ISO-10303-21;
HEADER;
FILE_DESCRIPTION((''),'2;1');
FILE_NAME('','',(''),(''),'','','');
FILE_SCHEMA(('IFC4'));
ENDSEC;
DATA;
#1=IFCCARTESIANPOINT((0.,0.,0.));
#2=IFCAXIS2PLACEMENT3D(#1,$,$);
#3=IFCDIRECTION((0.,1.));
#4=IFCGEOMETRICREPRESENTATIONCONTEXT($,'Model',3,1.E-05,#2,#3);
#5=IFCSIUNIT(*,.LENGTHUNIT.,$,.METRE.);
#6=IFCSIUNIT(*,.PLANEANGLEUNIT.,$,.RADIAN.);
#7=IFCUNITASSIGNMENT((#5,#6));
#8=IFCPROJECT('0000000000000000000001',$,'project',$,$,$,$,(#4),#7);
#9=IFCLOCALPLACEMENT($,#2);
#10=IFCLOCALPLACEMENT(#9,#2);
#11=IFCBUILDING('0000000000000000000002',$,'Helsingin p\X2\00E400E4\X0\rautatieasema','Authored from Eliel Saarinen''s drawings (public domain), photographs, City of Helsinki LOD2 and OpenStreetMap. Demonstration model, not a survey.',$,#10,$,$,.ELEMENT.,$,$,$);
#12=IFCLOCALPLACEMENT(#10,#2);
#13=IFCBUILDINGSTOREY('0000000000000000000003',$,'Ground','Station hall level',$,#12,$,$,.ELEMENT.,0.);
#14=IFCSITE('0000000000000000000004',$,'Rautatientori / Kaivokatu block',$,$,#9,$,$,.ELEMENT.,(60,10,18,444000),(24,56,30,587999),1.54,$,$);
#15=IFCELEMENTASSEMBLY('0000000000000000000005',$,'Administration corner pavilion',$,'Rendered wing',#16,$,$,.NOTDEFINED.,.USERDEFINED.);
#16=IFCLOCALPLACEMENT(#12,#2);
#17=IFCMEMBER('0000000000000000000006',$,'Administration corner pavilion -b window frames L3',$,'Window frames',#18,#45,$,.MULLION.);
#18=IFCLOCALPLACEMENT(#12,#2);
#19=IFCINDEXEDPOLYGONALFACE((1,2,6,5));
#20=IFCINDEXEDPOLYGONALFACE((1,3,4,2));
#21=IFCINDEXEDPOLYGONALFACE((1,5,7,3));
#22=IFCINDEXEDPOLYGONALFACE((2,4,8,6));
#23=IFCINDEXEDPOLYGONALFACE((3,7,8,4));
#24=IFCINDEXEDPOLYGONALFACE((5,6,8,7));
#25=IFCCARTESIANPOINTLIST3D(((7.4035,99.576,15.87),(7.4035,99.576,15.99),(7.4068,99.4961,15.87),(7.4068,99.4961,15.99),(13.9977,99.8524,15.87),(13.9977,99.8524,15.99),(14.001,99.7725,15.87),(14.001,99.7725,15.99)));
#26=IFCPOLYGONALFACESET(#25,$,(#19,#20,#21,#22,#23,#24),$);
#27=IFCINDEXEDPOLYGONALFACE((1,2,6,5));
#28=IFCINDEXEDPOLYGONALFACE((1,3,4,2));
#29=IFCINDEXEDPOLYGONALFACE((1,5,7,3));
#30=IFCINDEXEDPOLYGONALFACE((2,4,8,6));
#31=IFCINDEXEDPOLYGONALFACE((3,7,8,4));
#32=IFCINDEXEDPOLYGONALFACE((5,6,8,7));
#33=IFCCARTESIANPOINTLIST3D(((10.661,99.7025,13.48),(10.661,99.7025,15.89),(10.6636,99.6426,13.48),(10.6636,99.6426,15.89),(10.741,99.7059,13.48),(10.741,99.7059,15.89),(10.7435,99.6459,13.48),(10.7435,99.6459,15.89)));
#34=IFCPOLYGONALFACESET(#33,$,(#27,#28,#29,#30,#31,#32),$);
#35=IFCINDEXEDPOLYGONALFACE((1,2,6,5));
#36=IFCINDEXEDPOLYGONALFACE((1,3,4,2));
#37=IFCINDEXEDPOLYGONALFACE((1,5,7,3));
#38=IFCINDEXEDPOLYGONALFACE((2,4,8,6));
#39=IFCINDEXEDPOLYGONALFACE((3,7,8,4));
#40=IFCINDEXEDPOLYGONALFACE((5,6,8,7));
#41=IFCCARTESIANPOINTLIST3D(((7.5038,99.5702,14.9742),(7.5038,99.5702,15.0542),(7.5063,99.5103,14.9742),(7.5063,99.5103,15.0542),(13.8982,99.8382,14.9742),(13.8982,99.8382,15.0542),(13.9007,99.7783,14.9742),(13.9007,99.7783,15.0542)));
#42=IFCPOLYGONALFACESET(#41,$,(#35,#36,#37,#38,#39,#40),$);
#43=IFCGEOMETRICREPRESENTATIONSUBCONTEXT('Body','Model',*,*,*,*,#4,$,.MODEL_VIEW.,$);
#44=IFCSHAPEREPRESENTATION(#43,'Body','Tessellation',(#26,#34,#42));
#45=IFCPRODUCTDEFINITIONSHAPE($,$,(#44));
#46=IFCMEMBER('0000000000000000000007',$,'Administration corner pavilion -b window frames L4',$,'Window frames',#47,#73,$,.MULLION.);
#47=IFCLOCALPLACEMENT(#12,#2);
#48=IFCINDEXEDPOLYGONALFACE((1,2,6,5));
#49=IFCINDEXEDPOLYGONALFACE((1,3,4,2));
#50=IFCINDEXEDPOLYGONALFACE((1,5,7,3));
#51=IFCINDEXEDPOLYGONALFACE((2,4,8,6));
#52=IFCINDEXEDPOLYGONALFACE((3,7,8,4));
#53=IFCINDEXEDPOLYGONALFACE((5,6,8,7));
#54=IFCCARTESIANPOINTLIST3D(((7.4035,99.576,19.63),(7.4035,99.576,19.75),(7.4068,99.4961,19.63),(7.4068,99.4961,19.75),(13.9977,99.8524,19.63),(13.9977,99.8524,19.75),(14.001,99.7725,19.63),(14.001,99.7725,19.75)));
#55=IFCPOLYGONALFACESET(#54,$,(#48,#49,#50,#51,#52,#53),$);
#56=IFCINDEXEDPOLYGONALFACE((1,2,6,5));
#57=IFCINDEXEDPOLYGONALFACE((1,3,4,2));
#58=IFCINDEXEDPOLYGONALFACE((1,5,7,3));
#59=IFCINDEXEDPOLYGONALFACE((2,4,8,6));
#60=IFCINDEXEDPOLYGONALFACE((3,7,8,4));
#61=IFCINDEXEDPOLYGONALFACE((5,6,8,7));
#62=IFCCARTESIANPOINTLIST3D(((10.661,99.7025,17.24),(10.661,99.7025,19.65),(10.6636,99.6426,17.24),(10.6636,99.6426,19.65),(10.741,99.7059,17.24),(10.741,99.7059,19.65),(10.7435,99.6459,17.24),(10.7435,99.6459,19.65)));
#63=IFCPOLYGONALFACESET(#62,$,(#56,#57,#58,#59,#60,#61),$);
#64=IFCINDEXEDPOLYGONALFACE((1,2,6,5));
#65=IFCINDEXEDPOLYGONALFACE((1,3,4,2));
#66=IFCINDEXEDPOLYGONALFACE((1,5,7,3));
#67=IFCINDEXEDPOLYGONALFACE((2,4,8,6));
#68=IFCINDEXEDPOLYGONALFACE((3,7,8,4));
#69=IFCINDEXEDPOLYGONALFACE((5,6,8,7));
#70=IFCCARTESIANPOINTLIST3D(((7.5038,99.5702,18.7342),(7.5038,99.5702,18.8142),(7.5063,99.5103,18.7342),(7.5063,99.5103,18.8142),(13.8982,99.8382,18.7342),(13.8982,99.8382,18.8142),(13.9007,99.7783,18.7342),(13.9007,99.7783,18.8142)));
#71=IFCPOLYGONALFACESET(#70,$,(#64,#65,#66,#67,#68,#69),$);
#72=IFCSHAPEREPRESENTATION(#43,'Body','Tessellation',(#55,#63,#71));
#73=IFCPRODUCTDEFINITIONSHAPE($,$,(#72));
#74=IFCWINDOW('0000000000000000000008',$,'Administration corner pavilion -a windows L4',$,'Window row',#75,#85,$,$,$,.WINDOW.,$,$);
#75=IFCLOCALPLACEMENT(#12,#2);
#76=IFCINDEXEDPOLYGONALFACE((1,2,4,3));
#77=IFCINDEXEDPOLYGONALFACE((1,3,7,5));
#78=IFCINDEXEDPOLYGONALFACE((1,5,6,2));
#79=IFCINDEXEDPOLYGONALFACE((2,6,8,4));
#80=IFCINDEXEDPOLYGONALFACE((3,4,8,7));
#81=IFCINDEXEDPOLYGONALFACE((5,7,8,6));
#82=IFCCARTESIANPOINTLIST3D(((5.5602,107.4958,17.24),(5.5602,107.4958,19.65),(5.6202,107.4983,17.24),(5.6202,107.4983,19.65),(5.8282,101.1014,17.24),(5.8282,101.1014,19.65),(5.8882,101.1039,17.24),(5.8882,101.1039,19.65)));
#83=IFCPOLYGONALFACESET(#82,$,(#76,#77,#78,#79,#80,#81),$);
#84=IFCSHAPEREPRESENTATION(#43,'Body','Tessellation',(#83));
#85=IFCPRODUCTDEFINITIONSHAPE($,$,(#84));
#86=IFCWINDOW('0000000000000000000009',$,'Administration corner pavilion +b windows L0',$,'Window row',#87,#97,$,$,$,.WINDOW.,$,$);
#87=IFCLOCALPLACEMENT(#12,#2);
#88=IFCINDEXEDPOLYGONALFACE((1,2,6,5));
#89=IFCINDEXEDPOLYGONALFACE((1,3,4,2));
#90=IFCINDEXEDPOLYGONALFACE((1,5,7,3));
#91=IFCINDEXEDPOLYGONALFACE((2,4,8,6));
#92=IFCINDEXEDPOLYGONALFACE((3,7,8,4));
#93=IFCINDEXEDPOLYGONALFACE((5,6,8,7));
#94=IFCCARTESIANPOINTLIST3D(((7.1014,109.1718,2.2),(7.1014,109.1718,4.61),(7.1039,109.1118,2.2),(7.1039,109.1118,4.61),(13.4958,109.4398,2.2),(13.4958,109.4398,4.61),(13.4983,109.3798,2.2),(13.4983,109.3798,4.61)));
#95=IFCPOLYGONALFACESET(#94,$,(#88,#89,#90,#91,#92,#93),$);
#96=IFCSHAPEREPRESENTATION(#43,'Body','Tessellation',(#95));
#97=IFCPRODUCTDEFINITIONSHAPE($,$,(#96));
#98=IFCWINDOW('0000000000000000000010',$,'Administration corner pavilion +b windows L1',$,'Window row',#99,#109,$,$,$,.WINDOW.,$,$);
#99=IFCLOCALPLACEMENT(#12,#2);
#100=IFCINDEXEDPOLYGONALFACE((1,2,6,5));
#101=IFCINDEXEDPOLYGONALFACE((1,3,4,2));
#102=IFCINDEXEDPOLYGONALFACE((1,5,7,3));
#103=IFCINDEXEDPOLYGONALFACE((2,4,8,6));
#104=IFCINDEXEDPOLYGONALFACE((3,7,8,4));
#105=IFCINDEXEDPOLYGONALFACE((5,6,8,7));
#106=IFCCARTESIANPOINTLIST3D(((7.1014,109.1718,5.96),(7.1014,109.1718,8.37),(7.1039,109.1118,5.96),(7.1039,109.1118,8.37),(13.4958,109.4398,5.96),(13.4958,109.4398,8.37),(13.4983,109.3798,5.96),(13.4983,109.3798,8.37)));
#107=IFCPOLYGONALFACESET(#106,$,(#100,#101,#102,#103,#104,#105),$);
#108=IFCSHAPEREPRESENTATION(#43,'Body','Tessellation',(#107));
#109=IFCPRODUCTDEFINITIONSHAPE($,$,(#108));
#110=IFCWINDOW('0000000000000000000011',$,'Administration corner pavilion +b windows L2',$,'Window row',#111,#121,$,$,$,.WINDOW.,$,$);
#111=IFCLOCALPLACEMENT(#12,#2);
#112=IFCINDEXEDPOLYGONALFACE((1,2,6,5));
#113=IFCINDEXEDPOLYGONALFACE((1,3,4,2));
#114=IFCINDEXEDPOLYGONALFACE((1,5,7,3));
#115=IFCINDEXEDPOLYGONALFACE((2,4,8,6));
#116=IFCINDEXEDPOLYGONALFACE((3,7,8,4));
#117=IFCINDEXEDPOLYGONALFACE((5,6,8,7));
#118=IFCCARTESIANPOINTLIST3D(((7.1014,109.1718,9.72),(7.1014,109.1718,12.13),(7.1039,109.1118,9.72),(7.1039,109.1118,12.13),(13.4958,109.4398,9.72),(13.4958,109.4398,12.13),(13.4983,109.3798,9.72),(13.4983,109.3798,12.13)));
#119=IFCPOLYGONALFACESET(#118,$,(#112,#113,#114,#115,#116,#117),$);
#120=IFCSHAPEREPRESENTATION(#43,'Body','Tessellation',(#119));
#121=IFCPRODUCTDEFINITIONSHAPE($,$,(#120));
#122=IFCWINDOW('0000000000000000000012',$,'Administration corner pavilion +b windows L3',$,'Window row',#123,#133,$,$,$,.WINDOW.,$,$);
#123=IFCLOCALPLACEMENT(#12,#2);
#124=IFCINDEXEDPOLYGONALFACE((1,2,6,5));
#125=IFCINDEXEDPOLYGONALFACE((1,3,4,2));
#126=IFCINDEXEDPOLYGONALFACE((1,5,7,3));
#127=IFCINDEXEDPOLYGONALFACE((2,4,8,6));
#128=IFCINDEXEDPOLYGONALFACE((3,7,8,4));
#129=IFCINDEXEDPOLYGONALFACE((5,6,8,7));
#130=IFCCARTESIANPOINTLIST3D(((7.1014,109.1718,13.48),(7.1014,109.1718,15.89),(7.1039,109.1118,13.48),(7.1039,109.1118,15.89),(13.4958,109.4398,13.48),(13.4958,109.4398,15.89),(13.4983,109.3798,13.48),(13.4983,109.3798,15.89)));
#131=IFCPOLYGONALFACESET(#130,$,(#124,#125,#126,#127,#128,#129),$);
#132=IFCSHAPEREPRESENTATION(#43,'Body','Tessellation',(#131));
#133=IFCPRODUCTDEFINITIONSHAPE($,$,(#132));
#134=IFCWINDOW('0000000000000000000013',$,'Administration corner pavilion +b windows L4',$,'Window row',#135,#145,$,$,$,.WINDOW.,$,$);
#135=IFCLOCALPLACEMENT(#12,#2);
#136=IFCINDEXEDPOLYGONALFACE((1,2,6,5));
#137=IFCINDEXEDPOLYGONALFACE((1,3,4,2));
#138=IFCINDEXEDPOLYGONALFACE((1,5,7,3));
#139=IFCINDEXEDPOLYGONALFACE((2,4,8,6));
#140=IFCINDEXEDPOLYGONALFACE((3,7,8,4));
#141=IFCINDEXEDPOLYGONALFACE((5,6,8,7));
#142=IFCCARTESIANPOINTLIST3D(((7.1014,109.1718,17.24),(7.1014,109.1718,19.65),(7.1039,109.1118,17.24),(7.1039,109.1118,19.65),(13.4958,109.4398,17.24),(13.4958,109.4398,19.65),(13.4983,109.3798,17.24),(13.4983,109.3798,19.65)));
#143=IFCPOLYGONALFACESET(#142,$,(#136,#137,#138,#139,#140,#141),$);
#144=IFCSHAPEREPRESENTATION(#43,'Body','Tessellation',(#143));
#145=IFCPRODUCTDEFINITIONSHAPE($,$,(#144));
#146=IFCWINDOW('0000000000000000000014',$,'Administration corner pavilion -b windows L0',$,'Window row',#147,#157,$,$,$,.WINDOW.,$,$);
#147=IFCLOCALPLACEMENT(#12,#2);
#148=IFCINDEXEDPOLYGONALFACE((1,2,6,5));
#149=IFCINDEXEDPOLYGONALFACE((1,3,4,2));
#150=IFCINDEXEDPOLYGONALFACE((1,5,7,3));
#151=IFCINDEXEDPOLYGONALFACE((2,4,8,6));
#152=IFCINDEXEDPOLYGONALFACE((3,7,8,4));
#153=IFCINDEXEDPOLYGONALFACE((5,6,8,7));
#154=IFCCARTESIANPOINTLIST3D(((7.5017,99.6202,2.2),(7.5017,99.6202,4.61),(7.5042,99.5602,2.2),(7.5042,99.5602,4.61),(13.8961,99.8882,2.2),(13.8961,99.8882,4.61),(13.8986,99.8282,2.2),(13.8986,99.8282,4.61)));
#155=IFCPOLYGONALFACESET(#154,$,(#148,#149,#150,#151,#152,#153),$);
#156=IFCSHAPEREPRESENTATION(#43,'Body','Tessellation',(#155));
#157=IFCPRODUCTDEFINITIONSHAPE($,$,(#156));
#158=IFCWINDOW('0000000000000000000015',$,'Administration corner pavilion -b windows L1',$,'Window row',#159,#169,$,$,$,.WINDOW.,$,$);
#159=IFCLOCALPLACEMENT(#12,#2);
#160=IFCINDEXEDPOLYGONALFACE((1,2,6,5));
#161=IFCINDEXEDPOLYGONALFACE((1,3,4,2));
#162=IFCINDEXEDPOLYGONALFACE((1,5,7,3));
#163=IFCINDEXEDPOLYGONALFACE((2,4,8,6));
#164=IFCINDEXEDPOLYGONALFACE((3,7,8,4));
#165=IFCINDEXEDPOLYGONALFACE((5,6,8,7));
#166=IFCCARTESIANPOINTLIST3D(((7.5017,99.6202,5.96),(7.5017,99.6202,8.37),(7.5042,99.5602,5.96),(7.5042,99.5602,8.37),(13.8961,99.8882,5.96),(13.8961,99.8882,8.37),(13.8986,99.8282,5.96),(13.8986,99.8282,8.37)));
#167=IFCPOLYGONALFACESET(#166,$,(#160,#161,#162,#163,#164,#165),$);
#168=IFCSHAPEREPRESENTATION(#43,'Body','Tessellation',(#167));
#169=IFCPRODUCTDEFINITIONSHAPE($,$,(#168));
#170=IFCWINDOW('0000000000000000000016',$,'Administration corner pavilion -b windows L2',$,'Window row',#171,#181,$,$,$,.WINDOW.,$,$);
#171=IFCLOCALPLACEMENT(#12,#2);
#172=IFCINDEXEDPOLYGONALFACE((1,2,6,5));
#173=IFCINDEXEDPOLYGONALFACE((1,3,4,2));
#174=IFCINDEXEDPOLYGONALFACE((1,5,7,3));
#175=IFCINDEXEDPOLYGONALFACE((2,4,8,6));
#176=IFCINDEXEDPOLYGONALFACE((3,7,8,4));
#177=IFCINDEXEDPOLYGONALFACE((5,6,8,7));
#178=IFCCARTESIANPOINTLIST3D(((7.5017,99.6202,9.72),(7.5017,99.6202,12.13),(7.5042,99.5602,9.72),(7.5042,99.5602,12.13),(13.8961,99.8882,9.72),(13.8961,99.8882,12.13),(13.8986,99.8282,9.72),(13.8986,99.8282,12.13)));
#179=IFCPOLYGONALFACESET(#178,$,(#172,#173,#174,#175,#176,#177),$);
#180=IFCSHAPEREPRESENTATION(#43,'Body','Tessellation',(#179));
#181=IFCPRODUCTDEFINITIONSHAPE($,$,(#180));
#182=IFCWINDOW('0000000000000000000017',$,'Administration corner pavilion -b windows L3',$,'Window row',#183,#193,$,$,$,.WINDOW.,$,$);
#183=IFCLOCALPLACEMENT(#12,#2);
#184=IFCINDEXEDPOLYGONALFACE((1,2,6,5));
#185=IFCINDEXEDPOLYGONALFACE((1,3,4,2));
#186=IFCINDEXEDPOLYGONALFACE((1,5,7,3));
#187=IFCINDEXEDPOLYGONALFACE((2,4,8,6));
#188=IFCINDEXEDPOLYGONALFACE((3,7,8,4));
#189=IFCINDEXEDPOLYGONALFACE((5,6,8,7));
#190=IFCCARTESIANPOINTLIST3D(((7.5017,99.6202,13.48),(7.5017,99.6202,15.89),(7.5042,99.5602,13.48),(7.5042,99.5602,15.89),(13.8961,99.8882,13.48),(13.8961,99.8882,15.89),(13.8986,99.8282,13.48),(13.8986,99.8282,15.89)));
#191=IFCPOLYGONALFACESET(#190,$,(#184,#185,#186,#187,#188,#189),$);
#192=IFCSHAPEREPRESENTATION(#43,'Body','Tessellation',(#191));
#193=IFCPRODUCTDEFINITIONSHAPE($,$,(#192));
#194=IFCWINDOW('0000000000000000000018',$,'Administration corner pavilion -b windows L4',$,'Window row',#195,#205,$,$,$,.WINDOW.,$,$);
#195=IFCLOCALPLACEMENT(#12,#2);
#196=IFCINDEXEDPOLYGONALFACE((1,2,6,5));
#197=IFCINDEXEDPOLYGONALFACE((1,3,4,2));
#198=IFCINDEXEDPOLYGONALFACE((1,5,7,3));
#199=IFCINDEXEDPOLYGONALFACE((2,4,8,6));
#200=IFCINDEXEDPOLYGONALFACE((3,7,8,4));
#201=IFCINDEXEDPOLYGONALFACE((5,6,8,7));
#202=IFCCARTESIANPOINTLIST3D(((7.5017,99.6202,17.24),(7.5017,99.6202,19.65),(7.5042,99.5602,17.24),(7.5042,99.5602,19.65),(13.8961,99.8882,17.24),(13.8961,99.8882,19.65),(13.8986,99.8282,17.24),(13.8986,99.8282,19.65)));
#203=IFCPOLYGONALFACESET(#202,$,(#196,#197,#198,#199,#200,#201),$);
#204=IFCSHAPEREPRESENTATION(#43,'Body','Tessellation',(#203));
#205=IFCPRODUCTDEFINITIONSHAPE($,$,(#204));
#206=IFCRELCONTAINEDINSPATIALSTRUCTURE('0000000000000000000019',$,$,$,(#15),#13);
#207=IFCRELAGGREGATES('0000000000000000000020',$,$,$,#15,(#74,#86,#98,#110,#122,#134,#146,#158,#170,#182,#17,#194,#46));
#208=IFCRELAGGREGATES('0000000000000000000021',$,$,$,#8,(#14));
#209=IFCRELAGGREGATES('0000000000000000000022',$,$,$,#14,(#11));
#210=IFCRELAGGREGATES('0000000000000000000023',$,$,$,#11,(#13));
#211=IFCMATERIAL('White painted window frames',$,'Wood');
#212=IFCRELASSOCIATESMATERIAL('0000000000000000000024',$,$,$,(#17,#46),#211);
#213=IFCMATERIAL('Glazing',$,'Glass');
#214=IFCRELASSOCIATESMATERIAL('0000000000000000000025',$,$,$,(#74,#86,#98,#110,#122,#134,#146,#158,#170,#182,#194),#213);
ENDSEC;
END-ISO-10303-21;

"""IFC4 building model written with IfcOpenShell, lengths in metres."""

from ifc_helpers import new_model, si_unit, direction, frame, frame_2d, origin, place, context, subcontext, project, spatial, rectangle, extrude, material, element, aggregate, save


model = new_model("IFC4")

# Units and contexts
model_context = context("Model", 3, precision=1e-05, world=origin(), true_north=direction((0.0, 1.0)))
body_context = subcontext(model_context, "Body", "Model", "MODEL_VIEW")
ifc_project = project(units=[si_unit("LENGTHUNIT", "METRE"), si_unit("PLANEANGLEUNIT", "RADIAN")], contexts=[model_context])

# Site, building, storey
site_placement = place(None, origin())
site = spatial("IfcSite", under=ifc_project, at=site_placement, Name="Rautatientori / Kaivokatu block", CompositionType="ELEMENT", RefLatitude=(60, 10, 18, 444000), RefLongitude=(24, 56, 30, 587999), RefElevation=1.54)
building_placement = place(site_placement, origin())
building = spatial("IfcBuilding", under=site, at=building_placement, Name="Helsingin päärautatieasema", Description="Authored from Eliel Saarinen's drawings (public domain), photographs, City of Helsinki LOD2 and OpenStreetMap. Demonstration model, not a survey.", CompositionType="ELEMENT")
storey_placement = place(building_placement, origin())
storey = spatial("IfcBuildingStorey", under=building, at=storey_placement, Name="Ground", Description="Station hall level", CompositionType="ELEMENT", Elevation=0.0)

# Element assembly, members, windows
assembly_placement = place(building_placement, origin())
assembly = element("IfcElementAssembly", 1, at=assembly_placement, inside=storey, Name="Administration corner pavilion", ObjectType="Rendered wing", AssemblyPlace="NOTDEFINED", PredefinedType="USERDEFINED")
ifc_material_1 = material(Name="White painted window frames", Category="Wood")
member_1_placement = place(building_placement, origin())
member_1 = element("IfcMember", 2, at=member_1_placement, material=ifc_material_1, Name="Administration corner pavilion -b window frames L3", ObjectType="Window frames", PredefinedType="MULLION", context=body_context, shape_type="SweptSolid", body=[
    extrude(rectangle(XDim=6.6, YDim=0.08, at=frame_2d((0.0, 0.0), x_axis=(0.999123, 0.041876))), frame((10.7023, 99.6742, 15.87)), (0.0, 0.0, 1.0), 0.12),
    extrude(rectangle(XDim=0.08, YDim=0.06, at=frame_2d((0.0, 0.0), x_axis=(0.999123, 0.041876))), frame((10.7023, 99.6742, 13.48)), (0.0, 0.0, 1.0), 2.41),
    extrude(rectangle(XDim=6.4, YDim=0.06, at=frame_2d((0.0, 0.0), x_axis=(0.999123, 0.041876))), frame((10.7023, 99.6742, 14.9742)), (0.0, 0.0, 1.0), 0.08),
])
member_2_placement = place(building_placement, origin())
member_2 = element("IfcMember", 3, at=member_2_placement, material=ifc_material_1, Name="Administration corner pavilion -b window frames L4", ObjectType="Window frames", PredefinedType="MULLION", context=body_context, shape_type="SweptSolid", body=[
    extrude(rectangle(XDim=6.6, YDim=0.08, at=frame_2d((0.0, 0.0), x_axis=(0.999123, 0.041876))), frame((10.7023, 99.6742, 19.63)), (0.0, 0.0, 1.0), 0.12),
    extrude(rectangle(XDim=0.08, YDim=0.06, at=frame_2d((0.0, 0.0), x_axis=(0.999123, 0.041876))), frame((10.7023, 99.6742, 17.24)), (0.0, 0.0, 1.0), 2.41),
    extrude(rectangle(XDim=6.4, YDim=0.06, at=frame_2d((0.0, 0.0), x_axis=(0.999123, 0.041876))), frame((10.7023, 99.6742, 18.7342)), (0.0, 0.0, 1.0), 0.08),
])
ifc_material_2 = material(Name="Glazing", Category="Glass")
window_1_placement = place(building_placement, origin())
window_1 = element("IfcWindow", 4, at=window_1_placement, material=ifc_material_2, Name="Administration corner pavilion -a windows L4", ObjectType="Window row", PredefinedType="WINDOW", context=body_context, shape_type="SweptSolid", body=[
    extrude(rectangle(XDim=6.4, YDim=0.06, at=frame_2d((0.0, 0.0), x_axis=(0.041876, -0.999123))), frame((5.7242, 104.2998, 17.24)), (0.0, 0.0, 1.0), 2.41),
])
window_2_placement = place(building_placement, origin())
window_2 = element("IfcWindow", 5, at=window_2_placement, material=ifc_material_2, Name="Administration corner pavilion +b windows L0", ObjectType="Window row", PredefinedType="WINDOW", context=body_context, shape_type="SweptSolid", body=[
    extrude(rectangle(XDim=6.4, YDim=0.06, at=frame_2d((0.0, 0.0), x_axis=(-0.999123, -0.041876))), frame((10.2998, 109.2758, 2.2)), (0.0, 0.0, 1.0), 2.41),
])
window_3_placement = place(building_placement, origin())
window_3 = element("IfcWindow", 6, at=window_3_placement, material=ifc_material_2, Name="Administration corner pavilion +b windows L1", ObjectType="Window row", PredefinedType="WINDOW", context=body_context, shape_type="SweptSolid", body=[
    extrude(rectangle(XDim=6.4, YDim=0.06, at=frame_2d((0.0, 0.0), x_axis=(-0.999123, -0.041876))), frame((10.2998, 109.2758, 5.96)), (0.0, 0.0, 1.0), 2.41),
])
window_4_placement = place(building_placement, origin())
window_4 = element("IfcWindow", 7, at=window_4_placement, material=ifc_material_2, Name="Administration corner pavilion +b windows L2", ObjectType="Window row", PredefinedType="WINDOW", context=body_context, shape_type="SweptSolid", body=[
    extrude(rectangle(XDim=6.4, YDim=0.06, at=frame_2d((0.0, 0.0), x_axis=(-0.999123, -0.041876))), frame((10.2998, 109.2758, 9.72)), (0.0, 0.0, 1.0), 2.41),
])
window_5_placement = place(building_placement, origin())
window_5 = element("IfcWindow", 8, at=window_5_placement, material=ifc_material_2, Name="Administration corner pavilion +b windows L3", ObjectType="Window row", PredefinedType="WINDOW", context=body_context, shape_type="SweptSolid", body=[
    extrude(rectangle(XDim=6.4, YDim=0.06, at=frame_2d((0.0, 0.0), x_axis=(-0.999123, -0.041876))), frame((10.2998, 109.2758, 13.48)), (0.0, 0.0, 1.0), 2.41),
])
window_6_placement = place(building_placement, origin())
window_6 = element("IfcWindow", 9, at=window_6_placement, material=ifc_material_2, Name="Administration corner pavilion +b windows L4", ObjectType="Window row", PredefinedType="WINDOW", context=body_context, shape_type="SweptSolid", body=[
    extrude(rectangle(XDim=6.4, YDim=0.06, at=frame_2d((0.0, 0.0), x_axis=(-0.999123, -0.041876))), frame((10.2998, 109.2758, 17.24)), (0.0, 0.0, 1.0), 2.41),
])
window_7_placement = place(building_placement, origin())
window_7 = element("IfcWindow", 10, at=window_7_placement, material=ifc_material_2, Name="Administration corner pavilion -b windows L0", ObjectType="Window row", PredefinedType="WINDOW", context=body_context, shape_type="SweptSolid", body=[
    extrude(rectangle(XDim=6.4, YDim=0.06, at=frame_2d((0.0, 0.0), x_axis=(0.999123, 0.041876))), frame((10.7002, 99.7242, 2.2)), (0.0, 0.0, 1.0), 2.41),
])
window_8_placement = place(building_placement, origin())
window_8 = element("IfcWindow", 11, at=window_8_placement, material=ifc_material_2, Name="Administration corner pavilion -b windows L1", ObjectType="Window row", PredefinedType="WINDOW", context=body_context, shape_type="SweptSolid", body=[
    extrude(rectangle(XDim=6.4, YDim=0.06, at=frame_2d((0.0, 0.0), x_axis=(0.999123, 0.041876))), frame((10.7002, 99.7242, 5.96)), (0.0, 0.0, 1.0), 2.41),
])
window_9_placement = place(building_placement, origin())
window_9 = element("IfcWindow", 12, at=window_9_placement, material=ifc_material_2, Name="Administration corner pavilion -b windows L2", ObjectType="Window row", PredefinedType="WINDOW", context=body_context, shape_type="SweptSolid", body=[
    extrude(rectangle(XDim=6.4, YDim=0.06, at=frame_2d((0.0, 0.0), x_axis=(0.999123, 0.041876))), frame((10.7002, 99.7242, 9.72)), (0.0, 0.0, 1.0), 2.41),
])
window_10_placement = place(building_placement, origin())
window_10 = element("IfcWindow", 13, at=window_10_placement, material=ifc_material_2, Name="Administration corner pavilion -b windows L3", ObjectType="Window row", PredefinedType="WINDOW", context=body_context, shape_type="SweptSolid", body=[
    extrude(rectangle(XDim=6.4, YDim=0.06, at=frame_2d((0.0, 0.0), x_axis=(0.999123, 0.041876))), frame((10.7002, 99.7242, 13.48)), (0.0, 0.0, 1.0), 2.41),
])
window_11_placement = place(building_placement, origin())
window_11 = element("IfcWindow", 14, at=window_11_placement, material=ifc_material_2, Name="Administration corner pavilion -b windows L4", ObjectType="Window row", PredefinedType="WINDOW", context=body_context, shape_type="SweptSolid", body=[
    extrude(rectangle(XDim=6.4, YDim=0.06, at=frame_2d((0.0, 0.0), x_axis=(0.999123, 0.041876))), frame((10.7002, 99.7242, 17.24)), (0.0, 0.0, 1.0), 2.41),
])
aggregate(assembly, [window_1, window_2, window_3, window_4, window_5, window_6, window_7, window_8, window_9, window_10, member_1, window_11, member_2])

save(model, "model.ifc")
